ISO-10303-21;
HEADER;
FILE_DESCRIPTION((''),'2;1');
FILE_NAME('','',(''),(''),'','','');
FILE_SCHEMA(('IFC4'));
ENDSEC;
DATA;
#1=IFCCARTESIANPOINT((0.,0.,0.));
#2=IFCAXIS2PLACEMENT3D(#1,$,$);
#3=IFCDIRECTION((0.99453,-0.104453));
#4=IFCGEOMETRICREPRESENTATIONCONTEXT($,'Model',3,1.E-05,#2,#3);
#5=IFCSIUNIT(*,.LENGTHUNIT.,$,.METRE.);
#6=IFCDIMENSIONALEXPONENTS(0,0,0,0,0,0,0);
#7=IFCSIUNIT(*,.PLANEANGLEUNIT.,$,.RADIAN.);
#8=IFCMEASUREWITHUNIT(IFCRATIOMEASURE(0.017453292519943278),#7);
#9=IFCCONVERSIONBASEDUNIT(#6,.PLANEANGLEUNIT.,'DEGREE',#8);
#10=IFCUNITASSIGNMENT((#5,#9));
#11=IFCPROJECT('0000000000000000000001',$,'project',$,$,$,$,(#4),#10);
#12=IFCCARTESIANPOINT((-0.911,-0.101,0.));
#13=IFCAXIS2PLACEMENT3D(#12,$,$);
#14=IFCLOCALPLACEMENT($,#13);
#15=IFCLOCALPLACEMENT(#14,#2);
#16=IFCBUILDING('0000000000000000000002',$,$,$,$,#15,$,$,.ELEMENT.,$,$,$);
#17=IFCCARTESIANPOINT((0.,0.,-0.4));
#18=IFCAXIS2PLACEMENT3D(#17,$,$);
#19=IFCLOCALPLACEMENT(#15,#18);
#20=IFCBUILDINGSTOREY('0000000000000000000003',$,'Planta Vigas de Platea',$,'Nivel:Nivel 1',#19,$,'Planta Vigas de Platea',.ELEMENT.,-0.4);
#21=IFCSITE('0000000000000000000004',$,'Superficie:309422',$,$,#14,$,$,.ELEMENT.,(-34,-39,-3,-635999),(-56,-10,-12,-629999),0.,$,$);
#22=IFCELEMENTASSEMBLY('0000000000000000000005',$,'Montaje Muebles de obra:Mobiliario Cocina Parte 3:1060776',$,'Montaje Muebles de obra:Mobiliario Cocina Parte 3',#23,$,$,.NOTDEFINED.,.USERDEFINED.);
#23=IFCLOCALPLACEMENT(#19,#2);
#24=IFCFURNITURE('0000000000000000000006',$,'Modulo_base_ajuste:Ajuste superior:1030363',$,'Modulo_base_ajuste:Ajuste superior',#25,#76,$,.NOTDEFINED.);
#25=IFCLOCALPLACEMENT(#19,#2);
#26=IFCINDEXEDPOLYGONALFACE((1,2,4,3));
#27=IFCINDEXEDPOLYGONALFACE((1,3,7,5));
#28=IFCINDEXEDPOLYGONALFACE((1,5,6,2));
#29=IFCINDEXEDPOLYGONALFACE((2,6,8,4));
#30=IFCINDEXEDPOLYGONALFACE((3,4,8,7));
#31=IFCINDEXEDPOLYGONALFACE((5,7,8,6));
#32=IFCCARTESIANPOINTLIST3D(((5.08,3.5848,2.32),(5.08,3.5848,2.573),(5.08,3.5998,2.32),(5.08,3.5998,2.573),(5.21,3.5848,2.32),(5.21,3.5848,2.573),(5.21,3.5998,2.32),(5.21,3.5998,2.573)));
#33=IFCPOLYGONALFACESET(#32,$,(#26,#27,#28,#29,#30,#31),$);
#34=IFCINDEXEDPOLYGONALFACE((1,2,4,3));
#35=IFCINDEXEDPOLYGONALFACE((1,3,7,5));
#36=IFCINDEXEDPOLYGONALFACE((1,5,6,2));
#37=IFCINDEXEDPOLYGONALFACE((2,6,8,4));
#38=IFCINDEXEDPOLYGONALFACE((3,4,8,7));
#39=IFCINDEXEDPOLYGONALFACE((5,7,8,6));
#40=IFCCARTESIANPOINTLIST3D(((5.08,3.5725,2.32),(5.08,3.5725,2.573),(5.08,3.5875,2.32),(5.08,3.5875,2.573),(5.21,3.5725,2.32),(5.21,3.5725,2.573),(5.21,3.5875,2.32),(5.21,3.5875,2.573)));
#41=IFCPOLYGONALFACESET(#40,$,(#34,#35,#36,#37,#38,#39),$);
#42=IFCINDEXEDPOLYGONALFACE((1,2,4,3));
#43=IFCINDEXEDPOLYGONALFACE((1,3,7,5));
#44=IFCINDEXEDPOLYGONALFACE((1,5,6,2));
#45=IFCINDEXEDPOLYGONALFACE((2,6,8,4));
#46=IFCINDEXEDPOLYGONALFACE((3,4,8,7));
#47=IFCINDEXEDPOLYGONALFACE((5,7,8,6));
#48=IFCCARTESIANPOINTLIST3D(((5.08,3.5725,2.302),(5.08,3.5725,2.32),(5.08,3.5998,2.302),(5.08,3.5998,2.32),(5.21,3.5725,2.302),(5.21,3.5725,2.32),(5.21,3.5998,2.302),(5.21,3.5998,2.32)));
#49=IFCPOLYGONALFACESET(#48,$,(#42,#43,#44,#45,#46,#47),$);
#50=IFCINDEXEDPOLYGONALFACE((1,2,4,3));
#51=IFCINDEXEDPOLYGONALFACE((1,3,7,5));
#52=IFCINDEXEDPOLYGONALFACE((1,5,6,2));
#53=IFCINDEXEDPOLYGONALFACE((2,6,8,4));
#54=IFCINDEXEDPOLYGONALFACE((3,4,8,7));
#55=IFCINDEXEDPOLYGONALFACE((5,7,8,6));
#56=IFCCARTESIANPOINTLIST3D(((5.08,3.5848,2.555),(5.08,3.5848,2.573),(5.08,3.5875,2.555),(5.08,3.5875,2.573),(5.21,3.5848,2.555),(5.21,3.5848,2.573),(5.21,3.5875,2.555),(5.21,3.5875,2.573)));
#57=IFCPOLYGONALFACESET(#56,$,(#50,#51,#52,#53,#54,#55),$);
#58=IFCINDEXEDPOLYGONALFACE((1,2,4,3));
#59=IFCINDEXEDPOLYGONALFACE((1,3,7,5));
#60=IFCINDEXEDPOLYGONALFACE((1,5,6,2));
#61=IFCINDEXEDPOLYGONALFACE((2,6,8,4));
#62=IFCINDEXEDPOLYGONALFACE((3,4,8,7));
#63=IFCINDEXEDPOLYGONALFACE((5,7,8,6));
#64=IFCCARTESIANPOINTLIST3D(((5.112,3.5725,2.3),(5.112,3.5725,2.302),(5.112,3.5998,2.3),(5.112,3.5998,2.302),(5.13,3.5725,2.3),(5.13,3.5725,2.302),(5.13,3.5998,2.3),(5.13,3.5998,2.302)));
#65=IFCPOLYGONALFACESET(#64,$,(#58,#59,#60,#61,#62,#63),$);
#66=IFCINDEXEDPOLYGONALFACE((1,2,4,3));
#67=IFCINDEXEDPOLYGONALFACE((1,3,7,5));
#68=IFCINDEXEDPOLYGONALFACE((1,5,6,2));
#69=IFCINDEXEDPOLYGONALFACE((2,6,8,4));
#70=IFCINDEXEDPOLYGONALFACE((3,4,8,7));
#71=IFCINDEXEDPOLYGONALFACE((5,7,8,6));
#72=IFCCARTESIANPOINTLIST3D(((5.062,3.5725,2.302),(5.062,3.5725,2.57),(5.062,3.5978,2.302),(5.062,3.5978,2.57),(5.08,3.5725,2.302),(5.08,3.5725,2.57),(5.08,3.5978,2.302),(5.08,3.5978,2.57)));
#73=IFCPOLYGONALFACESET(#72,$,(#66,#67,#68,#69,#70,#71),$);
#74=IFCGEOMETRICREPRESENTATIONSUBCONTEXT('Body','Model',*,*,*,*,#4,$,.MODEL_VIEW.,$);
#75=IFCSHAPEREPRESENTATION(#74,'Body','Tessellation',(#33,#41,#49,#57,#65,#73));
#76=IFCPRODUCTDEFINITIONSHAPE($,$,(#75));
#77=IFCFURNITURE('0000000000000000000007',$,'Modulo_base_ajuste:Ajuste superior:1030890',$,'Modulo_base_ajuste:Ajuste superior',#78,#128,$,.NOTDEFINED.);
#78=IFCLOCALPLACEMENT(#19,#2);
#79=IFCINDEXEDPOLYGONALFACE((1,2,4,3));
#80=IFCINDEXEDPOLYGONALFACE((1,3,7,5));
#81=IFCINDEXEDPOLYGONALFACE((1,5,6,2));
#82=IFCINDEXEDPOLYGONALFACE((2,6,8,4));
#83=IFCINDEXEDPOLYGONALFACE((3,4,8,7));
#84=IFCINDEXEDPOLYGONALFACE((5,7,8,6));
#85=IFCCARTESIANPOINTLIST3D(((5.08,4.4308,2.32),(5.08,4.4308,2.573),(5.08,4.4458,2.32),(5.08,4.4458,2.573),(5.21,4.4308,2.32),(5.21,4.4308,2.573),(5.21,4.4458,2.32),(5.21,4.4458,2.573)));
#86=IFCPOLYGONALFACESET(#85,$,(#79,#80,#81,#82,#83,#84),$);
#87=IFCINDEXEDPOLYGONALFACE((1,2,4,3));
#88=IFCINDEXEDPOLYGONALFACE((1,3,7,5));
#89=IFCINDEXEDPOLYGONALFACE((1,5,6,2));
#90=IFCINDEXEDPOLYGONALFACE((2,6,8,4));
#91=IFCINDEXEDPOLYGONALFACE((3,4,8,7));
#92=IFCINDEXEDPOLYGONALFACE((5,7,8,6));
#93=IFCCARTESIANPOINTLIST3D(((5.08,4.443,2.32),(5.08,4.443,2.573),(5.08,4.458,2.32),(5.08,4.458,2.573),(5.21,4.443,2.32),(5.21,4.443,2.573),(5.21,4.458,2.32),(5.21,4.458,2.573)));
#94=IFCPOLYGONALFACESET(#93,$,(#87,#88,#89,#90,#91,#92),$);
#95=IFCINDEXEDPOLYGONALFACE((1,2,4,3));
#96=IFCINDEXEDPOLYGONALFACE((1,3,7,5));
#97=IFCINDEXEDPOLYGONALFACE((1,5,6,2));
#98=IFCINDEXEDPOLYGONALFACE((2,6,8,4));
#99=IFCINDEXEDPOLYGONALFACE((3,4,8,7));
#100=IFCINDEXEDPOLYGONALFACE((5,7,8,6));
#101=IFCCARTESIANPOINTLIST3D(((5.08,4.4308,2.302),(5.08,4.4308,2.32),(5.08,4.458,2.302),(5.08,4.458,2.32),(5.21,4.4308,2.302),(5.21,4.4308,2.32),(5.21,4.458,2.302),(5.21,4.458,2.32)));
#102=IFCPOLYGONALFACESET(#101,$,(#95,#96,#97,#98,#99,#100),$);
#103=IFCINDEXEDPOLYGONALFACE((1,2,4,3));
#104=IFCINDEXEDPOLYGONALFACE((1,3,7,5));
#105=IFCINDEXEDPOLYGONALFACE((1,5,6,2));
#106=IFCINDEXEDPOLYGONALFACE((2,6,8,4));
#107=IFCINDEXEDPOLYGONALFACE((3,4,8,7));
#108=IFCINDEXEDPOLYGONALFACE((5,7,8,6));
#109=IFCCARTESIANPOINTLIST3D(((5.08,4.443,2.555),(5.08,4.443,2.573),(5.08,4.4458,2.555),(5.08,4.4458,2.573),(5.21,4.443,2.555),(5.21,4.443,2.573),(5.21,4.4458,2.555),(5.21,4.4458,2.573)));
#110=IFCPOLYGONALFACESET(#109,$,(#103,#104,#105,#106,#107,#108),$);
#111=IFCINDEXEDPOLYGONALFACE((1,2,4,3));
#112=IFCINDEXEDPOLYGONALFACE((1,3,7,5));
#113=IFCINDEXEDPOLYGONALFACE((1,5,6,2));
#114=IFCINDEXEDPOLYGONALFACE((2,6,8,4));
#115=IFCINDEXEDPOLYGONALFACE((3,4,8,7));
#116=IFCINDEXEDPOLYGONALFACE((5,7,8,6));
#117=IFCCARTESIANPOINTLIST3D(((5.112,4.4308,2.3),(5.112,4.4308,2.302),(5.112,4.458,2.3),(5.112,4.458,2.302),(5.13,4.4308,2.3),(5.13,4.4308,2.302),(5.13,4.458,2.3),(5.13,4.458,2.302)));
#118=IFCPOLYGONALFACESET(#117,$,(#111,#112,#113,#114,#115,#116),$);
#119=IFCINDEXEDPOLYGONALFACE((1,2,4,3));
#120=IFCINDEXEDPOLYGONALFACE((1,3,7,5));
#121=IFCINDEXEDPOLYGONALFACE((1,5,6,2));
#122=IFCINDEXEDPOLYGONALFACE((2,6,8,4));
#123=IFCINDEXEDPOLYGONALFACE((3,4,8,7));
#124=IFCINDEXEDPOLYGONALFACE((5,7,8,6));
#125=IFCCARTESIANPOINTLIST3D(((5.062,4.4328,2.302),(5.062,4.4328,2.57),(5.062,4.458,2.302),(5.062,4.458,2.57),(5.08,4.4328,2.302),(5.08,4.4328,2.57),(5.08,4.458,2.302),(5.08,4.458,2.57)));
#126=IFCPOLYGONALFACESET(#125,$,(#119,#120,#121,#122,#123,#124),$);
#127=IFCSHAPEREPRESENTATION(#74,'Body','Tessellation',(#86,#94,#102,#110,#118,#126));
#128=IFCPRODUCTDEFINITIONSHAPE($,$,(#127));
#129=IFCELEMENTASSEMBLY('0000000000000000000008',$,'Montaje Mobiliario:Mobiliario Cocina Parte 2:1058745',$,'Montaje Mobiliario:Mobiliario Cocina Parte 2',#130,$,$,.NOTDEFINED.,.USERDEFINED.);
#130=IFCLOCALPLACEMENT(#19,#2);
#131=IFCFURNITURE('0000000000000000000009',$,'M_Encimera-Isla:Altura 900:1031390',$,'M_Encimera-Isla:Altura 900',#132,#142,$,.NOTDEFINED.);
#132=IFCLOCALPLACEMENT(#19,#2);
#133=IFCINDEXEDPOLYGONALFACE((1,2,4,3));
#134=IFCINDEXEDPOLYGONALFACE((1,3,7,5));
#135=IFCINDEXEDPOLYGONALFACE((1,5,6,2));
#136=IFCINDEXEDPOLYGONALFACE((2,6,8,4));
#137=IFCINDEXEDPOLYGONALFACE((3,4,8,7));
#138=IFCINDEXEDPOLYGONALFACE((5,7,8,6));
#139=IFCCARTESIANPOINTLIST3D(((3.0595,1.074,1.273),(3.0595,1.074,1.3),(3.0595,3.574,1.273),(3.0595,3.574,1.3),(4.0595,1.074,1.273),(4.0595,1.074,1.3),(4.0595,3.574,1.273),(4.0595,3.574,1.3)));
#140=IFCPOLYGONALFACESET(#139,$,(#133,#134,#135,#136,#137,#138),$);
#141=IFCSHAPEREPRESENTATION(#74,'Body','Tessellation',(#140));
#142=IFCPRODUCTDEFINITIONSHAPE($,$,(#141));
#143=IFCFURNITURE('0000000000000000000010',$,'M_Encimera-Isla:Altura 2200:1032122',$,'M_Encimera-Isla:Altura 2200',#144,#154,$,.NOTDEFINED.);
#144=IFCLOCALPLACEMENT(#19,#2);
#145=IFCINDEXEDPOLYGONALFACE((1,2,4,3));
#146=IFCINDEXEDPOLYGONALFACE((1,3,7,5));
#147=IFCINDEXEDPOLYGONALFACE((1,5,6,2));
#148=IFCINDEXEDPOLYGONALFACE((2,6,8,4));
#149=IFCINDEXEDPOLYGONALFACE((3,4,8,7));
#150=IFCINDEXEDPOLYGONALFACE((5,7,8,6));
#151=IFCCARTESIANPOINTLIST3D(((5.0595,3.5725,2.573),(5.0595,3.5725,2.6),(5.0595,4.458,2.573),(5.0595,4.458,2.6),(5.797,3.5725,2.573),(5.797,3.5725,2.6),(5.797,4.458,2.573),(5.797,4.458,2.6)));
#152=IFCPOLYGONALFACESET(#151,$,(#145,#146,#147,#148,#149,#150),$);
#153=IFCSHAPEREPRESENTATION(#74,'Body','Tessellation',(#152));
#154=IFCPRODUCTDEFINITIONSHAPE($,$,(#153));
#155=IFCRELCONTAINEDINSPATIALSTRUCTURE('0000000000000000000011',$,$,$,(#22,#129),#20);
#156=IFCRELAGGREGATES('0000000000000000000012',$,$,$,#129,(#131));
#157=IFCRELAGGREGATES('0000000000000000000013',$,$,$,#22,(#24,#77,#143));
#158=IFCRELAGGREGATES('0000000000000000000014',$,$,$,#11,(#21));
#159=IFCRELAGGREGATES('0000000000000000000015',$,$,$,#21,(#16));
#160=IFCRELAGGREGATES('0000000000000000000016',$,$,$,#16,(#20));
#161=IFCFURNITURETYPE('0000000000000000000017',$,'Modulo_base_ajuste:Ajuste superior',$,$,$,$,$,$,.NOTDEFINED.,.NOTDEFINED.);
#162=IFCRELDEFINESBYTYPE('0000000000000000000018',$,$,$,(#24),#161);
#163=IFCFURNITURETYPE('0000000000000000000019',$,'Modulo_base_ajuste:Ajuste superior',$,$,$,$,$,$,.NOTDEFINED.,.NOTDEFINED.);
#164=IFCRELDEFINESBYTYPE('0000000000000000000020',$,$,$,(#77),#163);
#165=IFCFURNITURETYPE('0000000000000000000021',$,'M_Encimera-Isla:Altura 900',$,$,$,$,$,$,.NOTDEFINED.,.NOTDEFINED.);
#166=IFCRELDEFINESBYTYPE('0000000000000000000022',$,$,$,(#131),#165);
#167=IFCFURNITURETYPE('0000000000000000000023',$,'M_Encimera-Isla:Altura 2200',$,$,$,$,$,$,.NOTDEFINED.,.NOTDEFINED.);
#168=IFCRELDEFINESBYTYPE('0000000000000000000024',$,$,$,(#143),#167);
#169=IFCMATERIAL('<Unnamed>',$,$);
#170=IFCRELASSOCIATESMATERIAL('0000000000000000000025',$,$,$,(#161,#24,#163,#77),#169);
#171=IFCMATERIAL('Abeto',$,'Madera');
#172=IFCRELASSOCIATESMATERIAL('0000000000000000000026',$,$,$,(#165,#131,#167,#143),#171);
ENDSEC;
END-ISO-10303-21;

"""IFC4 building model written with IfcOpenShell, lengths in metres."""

from ifc_helpers import new_model, entity, si_unit, converted_unit, direction, frame, frame_2d, origin, origin_2d_with_axis, place, context, subcontext, project, spatial, rectangle, extrude, source, transform, mapped, material, type_object, type_shapes, element, aggregate, save


model = new_model("IFC4")

# Units and contexts
model_context = context("Model", 3, precision=1e-05, world=origin(), true_north=direction((0.99453, -0.104453)))
body_context = subcontext(model_context, "Body", "Model", "MODEL_VIEW")
ifc_project = project(units=[si_unit("LENGTHUNIT", "METRE"), converted_unit("PLANEANGLEUNIT", "DEGREE", entity("IfcRatioMeasure", 0.017453292519943278), si_unit("PLANEANGLEUNIT", "RADIAN"), dimensions=[0, 0, 0, 0, 0, 0, 0])], contexts=[model_context])

# Site, building, storey
site_placement = place(None, frame((-0.911, -0.101, 0.0)))
site = spatial("IfcSite", under=ifc_project, at=site_placement, Name="Superficie:309422", CompositionType="ELEMENT", RefLatitude=(-34, -39, -3, -635999), RefLongitude=(-56, -10, -12, -629999), RefElevation=0.0)
building_placement = place(site_placement, origin())
building = spatial("IfcBuilding", under=site, at=building_placement, CompositionType="ELEMENT")
storey_placement = place(building_placement, frame((0.0, 0.0, -0.4)))
storey = spatial("IfcBuildingStorey", under=building, at=storey_placement, Name="Planta Vigas de Platea", ObjectType="Nivel:Nivel 1", LongName="Planta Vigas de Platea", CompositionType="ELEMENT", Elevation=-0.4)

# Element assemblies, furniture
ifc_material_1 = material(Name="Abeto", Category="Madera")
ifc_material_2 = material(Name="<Unnamed>")
assembly_1_placement = place(storey_placement, origin())
assembly_1 = element("IfcElementAssembly", 1, at=assembly_1_placement, inside=storey, Name="Montaje Muebles de obra:Mobiliario Cocina Parte 3:1060776", ObjectType="Montaje Muebles de obra:Mobiliario Cocina Parte 3", AssemblyPlace="NOTDEFINED", PredefinedType="USERDEFINED")
furniture_type_1 = type_object("IfcFurnitureType", Name="Modulo_base_ajuste:Ajuste superior", AssemblyPlace="NOTDEFINED", PredefinedType="NOTDEFINED", material=ifc_material_2)
shared_shape_1 = source(origin(), body_context, "Body", "SweptSolid", [
    extrude(rectangle(XDim=0.015, YDim=0.13, at=frame_2d((0.0, 0.0), x_axis=(1.0, 0.0))), frame((0.083, 0.0197, 0.02), z_axis=(0.0, 0.0, 1.0), x_axis=(0.0, 1.0, 0.0)), (0.0, 0.0, 1.0), 0.253),
    extrude(rectangle(XDim=0.015, YDim=0.13, at=frame_2d((0.0, 0.0), x_axis=(1.0, 0.0))), frame((0.083, 0.0075, 0.02), z_axis=(0.0, 0.0, 1.0), x_axis=(0.0, -1.0, 0.0)), (0.0, 0.0, 1.0), 0.253),
    extrude(rectangle(XDim=0.0272, YDim=0.13, at=origin_2d_with_axis()), frame((0.083, 0.0136, 0.002), z_axis=(0.0, 0.0, 1.0), x_axis=(0.0, 1.0, 0.0)), (0.0, 0.0, 1.0), 0.018),
    extrude(rectangle(XDim=0.13, YDim=0.0028, at=frame_2d((0.0, 0.0), x_axis=(1.0, 0.0))), frame((0.083, 0.0136, 0.255), z_axis=(0.0, 0.0, 1.0), x_axis=(-1.0, 0.0, 0.0)), (0.0, 0.0, 1.0), 0.018),
    extrude(rectangle(XDim=0.018, YDim=0.0272, at=origin_2d_with_axis()), frame((0.059, 0.0136, 0.0), z_axis=(0.0, 0.0, 1.0), x_axis=(-1.0, 0.0, 0.0)), (0.0, 0.0, 1.0), 0.002),
    extrude(rectangle(XDim=0.018, YDim=0.0252, at=origin_2d_with_axis()), frame((0.009, 0.0126, 0.002)), (0.0, 0.0, 1.0), 0.268),
])
type_shapes(furniture_type_1, [shared_shape_1])
furniture_1_placement = place(assembly_1_placement, frame((5.062, 3.5725, 2.3)))
furniture_1 = element("IfcFurniture", 2, at=furniture_1_placement, type_object=furniture_type_1, material=ifc_material_2, Name="Modulo_base_ajuste:Ajuste superior:1030363", ObjectType="Modulo_base_ajuste:Ajuste superior", PredefinedType="NOTDEFINED", context=body_context, shape_type="MappedRepresentation", body=[
    mapped(shared_shape_1, transform((0.0, 0.0, 0.0), scale=1.0)),
])
furniture_type_2 = type_object("IfcFurnitureType", Name="Modulo_base_ajuste:Ajuste superior", AssemblyPlace="NOTDEFINED", PredefinedType="NOTDEFINED", material=ifc_material_2)
shared_shape_2 = source(origin(), body_context, "Body", "SweptSolid", [
    extrude(rectangle(XDim=0.13, YDim=0.015, at=origin_2d_with_axis()), frame((0.083, 0.0075, 0.02), z_axis=(0.0, 0.0, 1.0), x_axis=(-1.0, 0.0, 0.0)), (0.0, 0.0, 1.0), 0.253),
    extrude(rectangle(XDim=0.13, YDim=0.015, at=frame_2d((0.0, 0.0), x_axis=(1.0, 0.0))), frame((0.083, 0.0197, 0.02)), (0.0, 0.0, 1.0), 0.253),
    extrude(rectangle(XDim=0.13, YDim=0.0272, at=origin_2d_with_axis()), frame((0.083, 0.0136, 0.002), z_axis=(0.0, 0.0, 1.0), x_axis=(-1.0, 0.0, 0.0)), (0.0, 0.0, 1.0), 0.018),
    extrude(rectangle(XDim=0.0028, YDim=0.13, at=frame_2d((0.0, 0.0), x_axis=(1.0, 0.0))), frame((0.083, 0.0136, 0.255), z_axis=(0.0, 0.0, 1.0), x_axis=(0.0, 1.0, 0.0)), (0.0, 0.0, 1.0), 0.018),
    extrude(rectangle(XDim=0.0272, YDim=0.018, at=frame_2d((0.0, 0.0), x_axis=(1.0, 0.0))), frame((0.059, 0.0136, 0.0), z_axis=(0.0, 0.0, 1.0), x_axis=(0.0, 1.0, 0.0)), (0.0, 0.0, 1.0), 0.002),
    extrude(rectangle(XDim=0.0252, YDim=0.018, at=frame_2d((0.0, 0.0), x_axis=(1.0, 0.0))), frame((0.009, 0.0146, 0.002), z_axis=(0.0, 0.0, 1.0), x_axis=(0.0, -1.0, 0.0)), (0.0, 0.0, 1.0), 0.268),
])
type_shapes(furniture_type_2, [shared_shape_2])
furniture_2_placement = place(assembly_1_placement, frame((5.062, 4.4308, 2.3)))
furniture_2 = element("IfcFurniture", 3, at=furniture_2_placement, type_object=furniture_type_2, material=ifc_material_2, Name="Modulo_base_ajuste:Ajuste superior:1030890", ObjectType="Modulo_base_ajuste:Ajuste superior", PredefinedType="NOTDEFINED", context=body_context, shape_type="MappedRepresentation", body=[
    mapped(shared_shape_2, transform((0.0, 0.0, 0.0), scale=1.0)),
])
assembly_2_placement = place(storey_placement, origin())
assembly_2 = element("IfcElementAssembly", 4, at=assembly_2_placement, inside=storey, Name="Montaje Mobiliario:Mobiliario Cocina Parte 2:1058745", ObjectType="Montaje Mobiliario:Mobiliario Cocina Parte 2", AssemblyPlace="NOTDEFINED", PredefinedType="USERDEFINED")
furniture_type_3 = type_object("IfcFurnitureType", Name="M_Encimera-Isla:Altura 900", AssemblyPlace="NOTDEFINED", PredefinedType="NOTDEFINED", material=ifc_material_1)
shared_shape_3 = source(origin(), body_context, "Body", "SweptSolid", [
    extrude(rectangle(XDim=2.5, YDim=1.0, at=frame_2d((0.0, 0.0), x_axis=(1.0, 0.0))), frame((1.25, 0.5, 0.0), z_axis=(0.0, 0.0, 1.0), x_axis=(-1.0, 0.0, 0.0)), (0.0, 0.0, 1.0), 0.027),
])
type_shapes(furniture_type_3, [shared_shape_3])
furniture_3_placement = place(assembly_2_placement, frame((4.0595, 1.074, 1.273), z_axis=(0.0, 0.0, 1.0), x_axis=(0.0, 1.0, 0.0)))
furniture_3 = element("IfcFurniture", 5, at=furniture_3_placement, type_object=furniture_type_3, material=ifc_material_1, Name="M_Encimera-Isla:Altura 900:1031390", ObjectType="M_Encimera-Isla:Altura 900", PredefinedType="NOTDEFINED", context=body_context, shape_type="MappedRepresentation", body=[
    mapped(shared_shape_3, transform((0.0, 0.0, 0.0), scale=1.0)),
])

# Furniture
furniture_type_4 = type_object("IfcFurnitureType", Name="M_Encimera-Isla:Altura 2200", AssemblyPlace="NOTDEFINED", PredefinedType="NOTDEFINED", material=ifc_material_1)
shared_shape_4 = source(origin(), body_context, "Body", "SweptSolid", [
    extrude(rectangle(XDim=0.8855, YDim=0.7375, at=frame_2d((0.0, 0.0), x_axis=(1.0, 0.0))), frame((0.4427, 0.3688, 0.0), z_axis=(0.0, 0.0, 1.0), x_axis=(-1.0, 0.0, 0.0)), (0.0, 0.0, 1.0), 0.027),
])
type_shapes(furniture_type_4, [shared_shape_4])
furniture_4_placement = place(assembly_1_placement, frame((5.797, 3.5725, 2.573), z_axis=(0.0, 0.0, 1.0), x_axis=(0.0, 1.0, 0.0)))
furniture_4 = element("IfcFurniture", 6, at=furniture_4_placement, type_object=furniture_type_4, material=ifc_material_1, Name="M_Encimera-Isla:Altura 2200:1032122", ObjectType="M_Encimera-Isla:Altura 2200", PredefinedType="NOTDEFINED", context=body_context, shape_type="MappedRepresentation", body=[
    mapped(shared_shape_4, transform((0.0, 0.0, 0.0), scale=1.0)),
])
aggregate(assembly_2, [furniture_3])
aggregate(assembly_1, [furniture_1, furniture_2, furniture_4])

save(model, "model.ifc")
